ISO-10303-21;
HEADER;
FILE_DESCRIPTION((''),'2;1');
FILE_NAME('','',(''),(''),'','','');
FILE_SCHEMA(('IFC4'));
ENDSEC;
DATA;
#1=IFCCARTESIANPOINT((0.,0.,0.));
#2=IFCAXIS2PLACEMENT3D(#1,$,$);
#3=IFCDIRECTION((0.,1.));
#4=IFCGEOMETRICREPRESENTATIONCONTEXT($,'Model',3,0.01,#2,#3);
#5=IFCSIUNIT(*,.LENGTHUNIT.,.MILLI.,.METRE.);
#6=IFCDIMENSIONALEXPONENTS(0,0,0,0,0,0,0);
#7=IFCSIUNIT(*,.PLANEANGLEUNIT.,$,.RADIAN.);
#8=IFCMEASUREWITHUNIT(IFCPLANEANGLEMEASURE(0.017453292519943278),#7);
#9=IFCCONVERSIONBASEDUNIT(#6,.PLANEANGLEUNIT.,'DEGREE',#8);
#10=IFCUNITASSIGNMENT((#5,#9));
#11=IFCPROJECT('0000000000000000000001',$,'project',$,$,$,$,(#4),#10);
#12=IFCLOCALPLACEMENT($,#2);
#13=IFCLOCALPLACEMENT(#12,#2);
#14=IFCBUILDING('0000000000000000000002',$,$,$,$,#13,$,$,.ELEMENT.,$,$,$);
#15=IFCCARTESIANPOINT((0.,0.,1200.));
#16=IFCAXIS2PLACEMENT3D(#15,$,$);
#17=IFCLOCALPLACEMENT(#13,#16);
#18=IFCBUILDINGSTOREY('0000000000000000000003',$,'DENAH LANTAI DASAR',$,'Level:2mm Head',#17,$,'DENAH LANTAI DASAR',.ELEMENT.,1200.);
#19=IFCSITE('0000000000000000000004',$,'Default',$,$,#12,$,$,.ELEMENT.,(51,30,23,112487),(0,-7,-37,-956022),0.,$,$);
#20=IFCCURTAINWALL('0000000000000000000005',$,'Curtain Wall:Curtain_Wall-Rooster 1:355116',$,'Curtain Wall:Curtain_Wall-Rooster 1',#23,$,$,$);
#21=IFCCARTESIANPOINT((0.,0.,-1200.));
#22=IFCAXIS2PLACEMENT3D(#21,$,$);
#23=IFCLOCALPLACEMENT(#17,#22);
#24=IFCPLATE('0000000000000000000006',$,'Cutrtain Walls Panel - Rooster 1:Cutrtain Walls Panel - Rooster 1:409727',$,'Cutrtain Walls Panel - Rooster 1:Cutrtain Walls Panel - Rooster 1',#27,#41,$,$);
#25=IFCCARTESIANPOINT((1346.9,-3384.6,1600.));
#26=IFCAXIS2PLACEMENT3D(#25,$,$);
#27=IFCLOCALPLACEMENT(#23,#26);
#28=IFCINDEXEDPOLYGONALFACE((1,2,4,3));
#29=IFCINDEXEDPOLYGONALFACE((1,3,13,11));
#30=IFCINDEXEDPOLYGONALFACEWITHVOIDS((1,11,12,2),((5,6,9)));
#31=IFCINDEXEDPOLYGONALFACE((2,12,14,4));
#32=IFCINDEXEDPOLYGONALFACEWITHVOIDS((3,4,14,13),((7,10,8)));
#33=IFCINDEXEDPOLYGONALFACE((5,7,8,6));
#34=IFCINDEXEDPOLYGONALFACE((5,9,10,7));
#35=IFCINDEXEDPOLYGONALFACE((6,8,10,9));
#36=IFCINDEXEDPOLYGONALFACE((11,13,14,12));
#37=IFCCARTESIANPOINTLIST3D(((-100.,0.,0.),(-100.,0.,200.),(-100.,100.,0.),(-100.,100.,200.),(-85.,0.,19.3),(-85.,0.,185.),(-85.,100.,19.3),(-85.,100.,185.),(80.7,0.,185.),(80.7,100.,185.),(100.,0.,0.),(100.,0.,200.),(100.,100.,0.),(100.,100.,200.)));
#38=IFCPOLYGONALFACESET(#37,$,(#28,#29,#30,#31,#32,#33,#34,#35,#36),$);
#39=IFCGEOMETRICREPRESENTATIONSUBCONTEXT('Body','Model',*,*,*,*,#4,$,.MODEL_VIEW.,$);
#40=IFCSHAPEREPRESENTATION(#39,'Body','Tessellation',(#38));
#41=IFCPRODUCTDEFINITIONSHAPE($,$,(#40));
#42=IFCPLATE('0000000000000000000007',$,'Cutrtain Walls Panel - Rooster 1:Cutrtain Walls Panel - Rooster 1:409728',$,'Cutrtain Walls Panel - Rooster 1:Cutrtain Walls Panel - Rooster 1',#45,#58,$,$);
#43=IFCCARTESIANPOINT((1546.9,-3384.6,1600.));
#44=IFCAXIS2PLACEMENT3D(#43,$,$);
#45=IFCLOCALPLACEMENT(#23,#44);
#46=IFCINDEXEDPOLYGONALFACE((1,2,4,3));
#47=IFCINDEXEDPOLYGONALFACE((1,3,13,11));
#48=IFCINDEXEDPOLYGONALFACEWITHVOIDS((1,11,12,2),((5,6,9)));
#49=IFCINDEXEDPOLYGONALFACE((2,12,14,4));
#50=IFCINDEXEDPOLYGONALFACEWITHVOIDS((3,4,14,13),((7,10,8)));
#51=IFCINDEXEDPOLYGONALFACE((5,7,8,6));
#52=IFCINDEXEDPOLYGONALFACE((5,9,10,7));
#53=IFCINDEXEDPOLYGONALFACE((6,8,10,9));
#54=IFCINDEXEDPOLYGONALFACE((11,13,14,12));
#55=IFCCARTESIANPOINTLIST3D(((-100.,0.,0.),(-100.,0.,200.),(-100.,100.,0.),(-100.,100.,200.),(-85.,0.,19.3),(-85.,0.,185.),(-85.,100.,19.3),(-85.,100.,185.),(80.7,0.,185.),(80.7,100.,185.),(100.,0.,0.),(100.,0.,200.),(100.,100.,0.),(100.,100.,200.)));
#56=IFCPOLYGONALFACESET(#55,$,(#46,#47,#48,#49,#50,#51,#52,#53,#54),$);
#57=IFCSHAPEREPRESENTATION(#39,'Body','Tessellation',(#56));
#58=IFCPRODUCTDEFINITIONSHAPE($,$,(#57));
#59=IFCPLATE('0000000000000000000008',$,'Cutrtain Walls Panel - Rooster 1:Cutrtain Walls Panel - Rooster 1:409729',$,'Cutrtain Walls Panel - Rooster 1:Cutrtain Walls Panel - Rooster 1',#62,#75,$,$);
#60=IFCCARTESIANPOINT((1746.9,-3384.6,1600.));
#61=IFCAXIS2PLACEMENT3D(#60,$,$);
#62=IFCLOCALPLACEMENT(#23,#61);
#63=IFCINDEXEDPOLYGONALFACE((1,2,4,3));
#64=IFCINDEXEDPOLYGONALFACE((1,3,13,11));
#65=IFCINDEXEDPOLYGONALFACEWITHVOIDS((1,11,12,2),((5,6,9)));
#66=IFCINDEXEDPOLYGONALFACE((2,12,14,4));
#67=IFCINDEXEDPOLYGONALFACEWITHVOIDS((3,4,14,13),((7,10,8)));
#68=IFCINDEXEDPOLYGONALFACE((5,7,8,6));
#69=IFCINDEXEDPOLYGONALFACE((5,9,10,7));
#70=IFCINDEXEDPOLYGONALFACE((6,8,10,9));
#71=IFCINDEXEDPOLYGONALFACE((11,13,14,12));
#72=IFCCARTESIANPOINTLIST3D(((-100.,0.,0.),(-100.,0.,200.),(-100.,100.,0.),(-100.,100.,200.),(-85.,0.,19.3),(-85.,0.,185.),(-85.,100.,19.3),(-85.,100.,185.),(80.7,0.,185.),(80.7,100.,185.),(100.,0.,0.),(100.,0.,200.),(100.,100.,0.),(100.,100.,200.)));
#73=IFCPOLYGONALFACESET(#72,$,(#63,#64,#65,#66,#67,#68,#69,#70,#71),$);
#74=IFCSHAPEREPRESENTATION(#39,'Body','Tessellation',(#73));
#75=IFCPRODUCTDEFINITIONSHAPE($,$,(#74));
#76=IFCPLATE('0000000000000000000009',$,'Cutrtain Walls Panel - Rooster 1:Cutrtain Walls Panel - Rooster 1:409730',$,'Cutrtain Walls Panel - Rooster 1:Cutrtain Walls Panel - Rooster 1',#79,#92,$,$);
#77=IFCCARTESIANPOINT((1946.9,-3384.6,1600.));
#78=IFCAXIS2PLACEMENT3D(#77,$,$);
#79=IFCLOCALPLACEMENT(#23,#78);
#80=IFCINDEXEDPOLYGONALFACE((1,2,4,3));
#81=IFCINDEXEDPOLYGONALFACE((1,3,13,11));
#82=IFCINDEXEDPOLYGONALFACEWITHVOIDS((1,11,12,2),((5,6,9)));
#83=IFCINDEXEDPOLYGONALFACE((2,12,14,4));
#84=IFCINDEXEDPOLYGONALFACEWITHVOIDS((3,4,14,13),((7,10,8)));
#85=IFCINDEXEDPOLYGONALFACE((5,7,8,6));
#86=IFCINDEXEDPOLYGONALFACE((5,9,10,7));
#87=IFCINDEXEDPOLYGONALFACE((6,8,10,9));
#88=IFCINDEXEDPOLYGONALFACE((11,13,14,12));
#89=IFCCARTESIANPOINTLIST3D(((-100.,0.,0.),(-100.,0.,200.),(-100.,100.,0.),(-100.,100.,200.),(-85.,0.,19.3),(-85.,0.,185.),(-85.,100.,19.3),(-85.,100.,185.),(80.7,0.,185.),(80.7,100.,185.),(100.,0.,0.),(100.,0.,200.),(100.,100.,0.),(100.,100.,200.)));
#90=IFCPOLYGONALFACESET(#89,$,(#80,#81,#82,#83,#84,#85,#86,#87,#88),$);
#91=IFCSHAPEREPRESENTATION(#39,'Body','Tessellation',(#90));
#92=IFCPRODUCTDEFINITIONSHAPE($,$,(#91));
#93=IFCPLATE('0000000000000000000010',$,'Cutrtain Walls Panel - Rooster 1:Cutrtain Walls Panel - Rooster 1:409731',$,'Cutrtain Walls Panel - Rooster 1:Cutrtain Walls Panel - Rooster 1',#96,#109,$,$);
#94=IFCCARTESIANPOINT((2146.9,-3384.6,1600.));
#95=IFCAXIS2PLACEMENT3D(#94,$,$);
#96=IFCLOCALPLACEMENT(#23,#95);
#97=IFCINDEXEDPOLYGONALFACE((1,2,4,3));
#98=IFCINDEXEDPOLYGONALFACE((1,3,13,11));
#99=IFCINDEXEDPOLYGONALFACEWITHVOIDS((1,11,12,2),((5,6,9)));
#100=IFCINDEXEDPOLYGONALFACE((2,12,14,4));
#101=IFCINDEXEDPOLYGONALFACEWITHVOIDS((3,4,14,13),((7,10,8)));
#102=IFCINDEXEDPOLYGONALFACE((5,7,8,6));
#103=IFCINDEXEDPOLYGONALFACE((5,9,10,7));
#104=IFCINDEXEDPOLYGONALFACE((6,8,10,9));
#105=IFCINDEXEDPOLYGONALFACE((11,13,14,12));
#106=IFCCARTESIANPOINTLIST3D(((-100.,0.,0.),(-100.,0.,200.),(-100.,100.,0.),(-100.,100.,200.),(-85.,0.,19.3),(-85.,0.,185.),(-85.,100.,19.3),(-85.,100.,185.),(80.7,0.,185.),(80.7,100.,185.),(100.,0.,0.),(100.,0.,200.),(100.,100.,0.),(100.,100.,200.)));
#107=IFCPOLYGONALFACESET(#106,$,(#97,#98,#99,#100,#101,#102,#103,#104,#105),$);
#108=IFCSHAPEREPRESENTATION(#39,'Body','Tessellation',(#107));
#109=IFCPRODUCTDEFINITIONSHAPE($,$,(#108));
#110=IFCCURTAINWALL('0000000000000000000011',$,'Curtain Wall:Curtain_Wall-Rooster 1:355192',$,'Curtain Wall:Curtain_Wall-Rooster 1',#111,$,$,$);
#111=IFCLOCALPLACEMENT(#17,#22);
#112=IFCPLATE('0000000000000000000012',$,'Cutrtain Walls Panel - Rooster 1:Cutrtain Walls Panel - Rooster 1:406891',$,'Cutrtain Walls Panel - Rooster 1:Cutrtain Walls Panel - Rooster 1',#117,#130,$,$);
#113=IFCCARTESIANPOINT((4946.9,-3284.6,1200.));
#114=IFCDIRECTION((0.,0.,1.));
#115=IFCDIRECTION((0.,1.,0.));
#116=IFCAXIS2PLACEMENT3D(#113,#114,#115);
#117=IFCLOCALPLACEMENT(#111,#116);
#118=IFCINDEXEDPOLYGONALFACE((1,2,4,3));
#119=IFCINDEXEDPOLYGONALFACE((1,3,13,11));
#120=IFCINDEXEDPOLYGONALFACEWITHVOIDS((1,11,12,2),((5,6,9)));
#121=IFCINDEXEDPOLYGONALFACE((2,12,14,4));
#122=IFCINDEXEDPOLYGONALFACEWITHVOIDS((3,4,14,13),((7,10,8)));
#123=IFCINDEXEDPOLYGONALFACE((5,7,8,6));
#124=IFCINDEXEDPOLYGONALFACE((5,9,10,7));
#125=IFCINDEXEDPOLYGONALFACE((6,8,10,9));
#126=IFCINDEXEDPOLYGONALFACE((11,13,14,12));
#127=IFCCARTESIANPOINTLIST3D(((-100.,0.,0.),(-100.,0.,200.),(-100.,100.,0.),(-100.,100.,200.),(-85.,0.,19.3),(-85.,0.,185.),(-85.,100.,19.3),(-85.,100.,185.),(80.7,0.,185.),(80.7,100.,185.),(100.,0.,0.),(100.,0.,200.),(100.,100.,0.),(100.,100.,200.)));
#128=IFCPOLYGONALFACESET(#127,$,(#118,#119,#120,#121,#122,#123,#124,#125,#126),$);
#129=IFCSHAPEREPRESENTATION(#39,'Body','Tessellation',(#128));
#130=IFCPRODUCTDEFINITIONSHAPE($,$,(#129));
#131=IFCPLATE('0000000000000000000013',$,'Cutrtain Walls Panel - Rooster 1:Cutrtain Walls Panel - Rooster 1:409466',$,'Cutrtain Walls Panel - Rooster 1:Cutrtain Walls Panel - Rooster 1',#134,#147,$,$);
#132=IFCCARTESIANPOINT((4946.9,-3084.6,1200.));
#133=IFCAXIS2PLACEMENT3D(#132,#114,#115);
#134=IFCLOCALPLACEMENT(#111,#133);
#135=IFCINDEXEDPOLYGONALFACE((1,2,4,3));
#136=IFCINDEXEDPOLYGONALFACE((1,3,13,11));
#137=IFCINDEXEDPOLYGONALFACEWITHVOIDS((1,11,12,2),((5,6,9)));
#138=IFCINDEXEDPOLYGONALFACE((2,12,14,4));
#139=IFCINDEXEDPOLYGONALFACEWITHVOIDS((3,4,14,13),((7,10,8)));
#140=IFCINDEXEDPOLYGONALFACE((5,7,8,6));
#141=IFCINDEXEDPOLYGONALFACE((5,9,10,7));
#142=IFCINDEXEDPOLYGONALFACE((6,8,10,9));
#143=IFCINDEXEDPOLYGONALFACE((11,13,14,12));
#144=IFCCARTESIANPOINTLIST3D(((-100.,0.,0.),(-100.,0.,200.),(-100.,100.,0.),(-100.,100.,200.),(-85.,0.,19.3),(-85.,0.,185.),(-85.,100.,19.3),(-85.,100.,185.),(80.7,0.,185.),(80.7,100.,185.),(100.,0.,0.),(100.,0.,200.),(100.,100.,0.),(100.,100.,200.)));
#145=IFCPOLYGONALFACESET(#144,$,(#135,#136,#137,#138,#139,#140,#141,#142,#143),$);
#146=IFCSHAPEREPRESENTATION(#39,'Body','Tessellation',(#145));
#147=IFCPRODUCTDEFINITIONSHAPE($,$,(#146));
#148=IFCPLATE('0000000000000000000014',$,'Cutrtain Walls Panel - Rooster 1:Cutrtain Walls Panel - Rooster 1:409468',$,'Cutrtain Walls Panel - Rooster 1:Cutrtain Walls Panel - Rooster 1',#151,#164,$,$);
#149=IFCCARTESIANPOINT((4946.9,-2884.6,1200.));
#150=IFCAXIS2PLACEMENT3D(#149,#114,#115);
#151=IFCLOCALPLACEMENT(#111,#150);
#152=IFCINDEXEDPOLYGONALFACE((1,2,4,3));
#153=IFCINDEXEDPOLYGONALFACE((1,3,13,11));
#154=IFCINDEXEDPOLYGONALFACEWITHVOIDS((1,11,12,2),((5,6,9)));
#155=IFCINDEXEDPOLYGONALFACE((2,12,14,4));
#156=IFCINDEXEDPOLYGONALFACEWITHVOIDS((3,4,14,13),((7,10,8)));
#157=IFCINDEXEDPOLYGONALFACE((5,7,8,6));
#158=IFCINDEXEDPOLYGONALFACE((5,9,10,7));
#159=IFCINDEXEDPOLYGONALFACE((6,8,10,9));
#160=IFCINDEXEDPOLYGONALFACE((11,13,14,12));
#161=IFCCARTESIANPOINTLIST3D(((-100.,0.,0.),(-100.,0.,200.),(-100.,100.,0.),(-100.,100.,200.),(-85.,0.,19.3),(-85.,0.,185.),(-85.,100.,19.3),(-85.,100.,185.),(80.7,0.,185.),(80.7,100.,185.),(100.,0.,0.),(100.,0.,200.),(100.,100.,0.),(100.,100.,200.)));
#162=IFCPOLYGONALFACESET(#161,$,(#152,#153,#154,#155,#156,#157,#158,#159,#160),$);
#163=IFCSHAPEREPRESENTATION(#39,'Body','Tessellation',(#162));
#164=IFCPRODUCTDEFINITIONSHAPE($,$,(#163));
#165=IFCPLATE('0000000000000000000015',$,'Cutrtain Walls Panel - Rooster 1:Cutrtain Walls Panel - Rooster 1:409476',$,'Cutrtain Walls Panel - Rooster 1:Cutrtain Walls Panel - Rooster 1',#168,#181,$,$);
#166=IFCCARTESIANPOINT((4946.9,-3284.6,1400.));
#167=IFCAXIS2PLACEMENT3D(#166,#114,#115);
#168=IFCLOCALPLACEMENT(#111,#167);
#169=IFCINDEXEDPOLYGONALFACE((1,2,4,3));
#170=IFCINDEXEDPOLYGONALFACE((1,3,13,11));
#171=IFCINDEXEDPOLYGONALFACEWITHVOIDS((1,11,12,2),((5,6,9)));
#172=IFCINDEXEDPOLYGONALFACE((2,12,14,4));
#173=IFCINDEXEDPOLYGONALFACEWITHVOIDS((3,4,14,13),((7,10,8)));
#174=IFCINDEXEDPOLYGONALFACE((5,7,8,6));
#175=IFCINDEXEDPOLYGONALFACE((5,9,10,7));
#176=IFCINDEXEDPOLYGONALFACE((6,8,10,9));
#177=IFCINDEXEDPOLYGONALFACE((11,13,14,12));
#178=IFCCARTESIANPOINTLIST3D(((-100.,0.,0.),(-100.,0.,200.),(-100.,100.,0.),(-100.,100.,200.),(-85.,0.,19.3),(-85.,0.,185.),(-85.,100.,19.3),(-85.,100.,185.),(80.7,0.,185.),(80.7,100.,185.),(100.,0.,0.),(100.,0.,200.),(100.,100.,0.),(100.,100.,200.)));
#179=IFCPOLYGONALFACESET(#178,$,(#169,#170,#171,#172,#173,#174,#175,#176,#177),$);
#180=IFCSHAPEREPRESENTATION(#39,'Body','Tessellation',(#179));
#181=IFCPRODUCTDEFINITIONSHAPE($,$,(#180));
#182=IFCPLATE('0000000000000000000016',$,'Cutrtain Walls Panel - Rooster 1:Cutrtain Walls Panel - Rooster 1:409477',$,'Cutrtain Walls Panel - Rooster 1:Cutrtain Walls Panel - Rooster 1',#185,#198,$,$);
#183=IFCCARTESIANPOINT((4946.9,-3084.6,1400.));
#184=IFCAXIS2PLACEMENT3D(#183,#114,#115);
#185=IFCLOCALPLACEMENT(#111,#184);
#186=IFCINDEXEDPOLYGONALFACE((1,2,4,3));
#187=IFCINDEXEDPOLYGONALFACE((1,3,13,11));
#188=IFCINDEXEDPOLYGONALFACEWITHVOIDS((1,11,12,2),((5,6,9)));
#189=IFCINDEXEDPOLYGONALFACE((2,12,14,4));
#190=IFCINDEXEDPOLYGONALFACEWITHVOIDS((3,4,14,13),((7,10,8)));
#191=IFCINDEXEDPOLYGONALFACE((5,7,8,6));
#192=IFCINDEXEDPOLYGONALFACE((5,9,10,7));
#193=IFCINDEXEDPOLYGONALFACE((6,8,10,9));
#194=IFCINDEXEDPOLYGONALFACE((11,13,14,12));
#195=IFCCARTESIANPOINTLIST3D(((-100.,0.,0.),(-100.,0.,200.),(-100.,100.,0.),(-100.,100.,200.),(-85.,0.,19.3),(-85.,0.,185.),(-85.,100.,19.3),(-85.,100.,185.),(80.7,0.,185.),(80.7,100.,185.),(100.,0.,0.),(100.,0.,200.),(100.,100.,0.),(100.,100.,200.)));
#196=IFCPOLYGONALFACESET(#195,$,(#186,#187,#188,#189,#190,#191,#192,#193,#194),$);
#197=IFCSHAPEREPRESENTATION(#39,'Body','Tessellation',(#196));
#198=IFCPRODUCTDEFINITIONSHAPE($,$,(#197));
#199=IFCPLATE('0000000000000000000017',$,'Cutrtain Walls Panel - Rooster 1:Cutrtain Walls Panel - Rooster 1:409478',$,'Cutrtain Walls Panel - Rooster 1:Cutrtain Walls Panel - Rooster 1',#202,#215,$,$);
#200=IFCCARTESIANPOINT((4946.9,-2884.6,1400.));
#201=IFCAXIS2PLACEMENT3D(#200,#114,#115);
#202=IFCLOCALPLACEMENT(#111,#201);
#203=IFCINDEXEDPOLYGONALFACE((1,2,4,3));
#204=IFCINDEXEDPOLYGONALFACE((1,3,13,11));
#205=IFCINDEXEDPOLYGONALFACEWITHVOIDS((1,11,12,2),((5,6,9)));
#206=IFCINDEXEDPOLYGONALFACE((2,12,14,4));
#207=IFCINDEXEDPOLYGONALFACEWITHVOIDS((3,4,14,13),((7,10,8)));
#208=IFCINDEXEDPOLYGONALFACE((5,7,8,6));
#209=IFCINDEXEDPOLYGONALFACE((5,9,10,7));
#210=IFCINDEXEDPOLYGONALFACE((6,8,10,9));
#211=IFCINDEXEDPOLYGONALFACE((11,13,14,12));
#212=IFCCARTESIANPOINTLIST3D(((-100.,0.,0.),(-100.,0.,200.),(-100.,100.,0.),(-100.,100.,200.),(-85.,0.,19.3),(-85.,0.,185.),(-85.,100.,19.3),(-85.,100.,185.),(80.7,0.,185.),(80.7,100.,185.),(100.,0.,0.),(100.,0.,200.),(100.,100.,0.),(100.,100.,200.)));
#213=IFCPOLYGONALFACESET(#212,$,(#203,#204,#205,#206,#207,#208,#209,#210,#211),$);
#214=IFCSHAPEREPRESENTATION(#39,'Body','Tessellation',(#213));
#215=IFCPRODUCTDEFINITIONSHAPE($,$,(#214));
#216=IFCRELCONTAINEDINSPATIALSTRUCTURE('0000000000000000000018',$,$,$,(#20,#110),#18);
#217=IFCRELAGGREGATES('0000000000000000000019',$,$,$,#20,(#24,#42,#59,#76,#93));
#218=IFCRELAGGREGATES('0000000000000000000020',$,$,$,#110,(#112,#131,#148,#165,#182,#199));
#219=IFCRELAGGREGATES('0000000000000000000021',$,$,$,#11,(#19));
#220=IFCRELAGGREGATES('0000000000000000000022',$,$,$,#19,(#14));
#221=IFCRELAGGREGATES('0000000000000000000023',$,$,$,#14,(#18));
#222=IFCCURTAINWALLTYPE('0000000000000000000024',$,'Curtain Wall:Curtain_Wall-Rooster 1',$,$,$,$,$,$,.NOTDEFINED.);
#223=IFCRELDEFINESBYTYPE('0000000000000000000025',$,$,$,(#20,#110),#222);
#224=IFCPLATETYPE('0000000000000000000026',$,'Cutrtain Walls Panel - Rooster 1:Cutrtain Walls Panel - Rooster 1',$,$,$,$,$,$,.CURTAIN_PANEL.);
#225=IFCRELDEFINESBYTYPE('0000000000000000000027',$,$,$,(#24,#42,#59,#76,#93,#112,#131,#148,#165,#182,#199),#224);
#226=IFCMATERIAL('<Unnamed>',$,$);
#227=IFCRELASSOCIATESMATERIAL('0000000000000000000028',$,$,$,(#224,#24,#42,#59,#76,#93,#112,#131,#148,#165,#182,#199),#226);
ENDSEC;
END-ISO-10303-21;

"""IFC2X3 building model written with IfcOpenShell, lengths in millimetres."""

from ifc_helpers import new_model, entity, si_unit, converted_unit, direction, frame, origin, place, context, subcontext, project, spatial, polyline, outline, extrude, source, transform, mapped, material, type_object, type_shapes, element, aggregate, save


model = new_model("IFC2X3")

# Units and contexts
model_context = context("Model", 3, precision=0.01, world=origin(), true_north=direction((0.0, 1.0)))
body_context = subcontext(model_context, "Body", "Model", "MODEL_VIEW")
ifc_project = project(units=[si_unit("LENGTHUNIT", "METRE", prefix="MILLI"), converted_unit("PLANEANGLEUNIT", "DEGREE", entity("IfcPlaneAngleMeasure", 0.017453292519943278), si_unit("PLANEANGLEUNIT", "RADIAN"), dimensions=[0, 0, 0, 0, 0, 0, 0])], contexts=[model_context])

# Site, building, storey
site_placement = place(None, origin())
site = spatial("IfcSite", under=ifc_project, at=site_placement, Name="Default", CompositionType="ELEMENT", RefLatitude=(51, 30, 23, 112487), RefLongitude=(0, -7, -37, -956022), RefElevation=0.0)
building_placement = place(site_placement, origin())
building = spatial("IfcBuilding", under=site, at=building_placement, CompositionType="ELEMENT")
storey_placement = place(building_placement, frame((0.0, 0.0, 1200.0)))
storey = spatial("IfcBuildingStorey", under=building, at=storey_placement, Name="DENAH LANTAI DASAR", ObjectType="Level:2mm Head", LongName="DENAH LANTAI DASAR", CompositionType="ELEMENT", Elevation=1200.0)

# Curtain walls, plates
curtain_wall_type = type_object("IfcCurtainWallType", Name="Curtain Wall:Curtain_Wall-Rooster 1", PredefinedType="NOTDEFINED")
curtain_wall_1_placement = place(storey_placement, frame((0.0, 0.0, -1200.0)))
curtain_wall_1 = element("IfcCurtainWall", 1, at=curtain_wall_1_placement, inside=storey, type_object=curtain_wall_type, Name="Curtain Wall:Curtain_Wall-Rooster 1:355116", ObjectType="Curtain Wall:Curtain_Wall-Rooster 1")
ifc_material_1 = material(Name="<Unnamed>")
plate_type = type_object("IfcPlateType", Name="Cutrtain Walls Panel - Rooster 1:Cutrtain Walls Panel - Rooster 1", PredefinedType="CURTAIN_PANEL", material=ifc_material_1)
shared_shape = source(origin(), body_context, "Body", "SweptSolid", [
    extrude(outline(polyline([(-100.0, -100.0), (100.0, -100.0), (100.0, 100.0), (-100.0, 100.0), (-100.0, -100.0)]), holes=[polyline([(80.7, 85.0), (-85.0, -80.7), (-85.0, 85.0), (80.7, 85.0)])]), frame((0.0, 0.0, 100.0), z_axis=(0.0, 1.0, 0.0), x_axis=(0.0, 0.0, -1.0)), (0.0, 0.0, 1.0), 100.0),
])
type_shapes(plate_type, [shared_shape])
plate_1_placement = place(curtain_wall_1_placement, frame((1346.9, -3384.6, 1600.0)))
plate_1 = element("IfcPlate", 2, at=plate_1_placement, type_object=plate_type, material=ifc_material_1, Name="Cutrtain Walls Panel - Rooster 1:Cutrtain Walls Panel - Rooster 1:409727", ObjectType="Cutrtain Walls Panel - Rooster 1:Cutrtain Walls Panel - Rooster 1", context=body_context, shape_type="MappedRepresentation", body=[
    mapped(shared_shape, transform((0.0, 0.0, 0.0), scale=1.0)),
])
plate_2_placement = place(curtain_wall_1_placement, frame((1546.9, -3384.6, 1600.0)))
plate_2 = element("IfcPlate", 3, at=plate_2_placement, type_object=plate_type, material=ifc_material_1, Name="Cutrtain Walls Panel - Rooster 1:Cutrtain Walls Panel - Rooster 1:409728", ObjectType="Cutrtain Walls Panel - Rooster 1:Cutrtain Walls Panel - Rooster 1", context=body_context, shape_type="MappedRepresentation", body=[
    mapped(shared_shape, transform((0.0, 0.0, 0.0), scale=1.0)),
])
plate_3_placement = place(curtain_wall_1_placement, frame((1746.9, -3384.6, 1600.0)))
plate_3 = element("IfcPlate", 4, at=plate_3_placement, type_object=plate_type, material=ifc_material_1, Name="Cutrtain Walls Panel - Rooster 1:Cutrtain Walls Panel - Rooster 1:409729", ObjectType="Cutrtain Walls Panel - Rooster 1:Cutrtain Walls Panel - Rooster 1", context=body_context, shape_type="MappedRepresentation", body=[
    mapped(shared_shape, transform((0.0, 0.0, 0.0), scale=1.0)),
])
plate_4_placement = place(curtain_wall_1_placement, frame((1946.9, -3384.6, 1600.0)))
plate_4 = element("IfcPlate", 5, at=plate_4_placement, type_object=plate_type, material=ifc_material_1, Name="Cutrtain Walls Panel - Rooster 1:Cutrtain Walls Panel - Rooster 1:409730", ObjectType="Cutrtain Walls Panel - Rooster 1:Cutrtain Walls Panel - Rooster 1", context=body_context, shape_type="MappedRepresentation", body=[
    mapped(shared_shape, transform((0.0, 0.0, 0.0), scale=1.0)),
])
plate_5_placement = place(curtain_wall_1_placement, frame((2146.9, -3384.6, 1600.0)))
plate_5 = element("IfcPlate", 6, at=plate_5_placement, type_object=plate_type, material=ifc_material_1, Name="Cutrtain Walls Panel - Rooster 1:Cutrtain Walls Panel - Rooster 1:409731", ObjectType="Cutrtain Walls Panel - Rooster 1:Cutrtain Walls Panel - Rooster 1", context=body_context, shape_type="MappedRepresentation", body=[
    mapped(shared_shape, transform((0.0, 0.0, 0.0), scale=1.0)),
])
aggregate(curtain_wall_1, [plate_1, plate_2, plate_3, plate_4, plate_5])
curtain_wall_2_placement = place(storey_placement, frame((0.0, 0.0, -1200.0)))
curtain_wall_2 = element("IfcCurtainWall", 7, at=curtain_wall_2_placement, inside=storey, type_object=curtain_wall_type, Name="Curtain Wall:Curtain_Wall-Rooster 1:355192", ObjectType="Curtain Wall:Curtain_Wall-Rooster 1")
plate_6_placement = place(curtain_wall_2_placement, frame((4946.9, -3284.6, 1200.0), z_axis=(0.0, 0.0, 1.0), x_axis=(0.0, 1.0, 0.0)))
plate_6 = element("IfcPlate", 8, at=plate_6_placement, type_object=plate_type, material=ifc_material_1, Name="Cutrtain Walls Panel - Rooster 1:Cutrtain Walls Panel - Rooster 1:406891", ObjectType="Cutrtain Walls Panel - Rooster 1:Cutrtain Walls Panel - Rooster 1", context=body_context, shape_type="MappedRepresentation", body=[
    mapped(shared_shape, transform((0.0, 0.0, 0.0), scale=1.0)),
])
plate_7_placement = place(curtain_wall_2_placement, frame((4946.9, -3084.6, 1200.0), z_axis=(0.0, 0.0, 1.0), x_axis=(0.0, 1.0, 0.0)))
plate_7 = element("IfcPlate", 9, at=plate_7_placement, type_object=plate_type, material=ifc_material_1, Name="Cutrtain Walls Panel - Rooster 1:Cutrtain Walls Panel - Rooster 1:409466", ObjectType="Cutrtain Walls Panel - Rooster 1:Cutrtain Walls Panel - Rooster 1", context=body_context, shape_type="MappedRepresentation", body=[
    mapped(shared_shape, transform((0.0, 0.0, 0.0), scale=1.0)),
])
plate_8_placement = place(curtain_wall_2_placement, frame((4946.9, -2884.6, 1200.0), z_axis=(0.0, 0.0, 1.0), x_axis=(0.0, 1.0, 0.0)))
plate_8 = element("IfcPlate", 10, at=plate_8_placement, type_object=plate_type, material=ifc_material_1, Name="Cutrtain Walls Panel - Rooster 1:Cutrtain Walls Panel - Rooster 1:409468", ObjectType="Cutrtain Walls Panel - Rooster 1:Cutrtain Walls Panel - Rooster 1", context=body_context, shape_type="MappedRepresentation", body=[
    mapped(shared_shape, transform((0.0, 0.0, 0.0), scale=1.0)),
])
plate_9_placement = place(curtain_wall_2_placement, frame((4946.9, -3284.6, 1400.0), z_axis=(0.0, 0.0, 1.0), x_axis=(0.0, 1.0, 0.0)))
plate_9 = element("IfcPlate", 11, at=plate_9_placement, type_object=plate_type, material=ifc_material_1, Name="Cutrtain Walls Panel - Rooster 1:Cutrtain Walls Panel - Rooster 1:409476", ObjectType="Cutrtain Walls Panel - Rooster 1:Cutrtain Walls Panel - Rooster 1", context=body_context, shape_type="MappedRepresentation", body=[
    mapped(shared_shape, transform((0.0, 0.0, 0.0), scale=1.0)),
])
plate_10_placement = place(curtain_wall_2_placement, frame((4946.9, -3084.6, 1400.0), z_axis=(0.0, 0.0, 1.0), x_axis=(0.0, 1.0, 0.0)))
plate_10 = element("IfcPlate", 12, at=plate_10_placement, type_object=plate_type, material=ifc_material_1, Name="Cutrtain Walls Panel - Rooster 1:Cutrtain Walls Panel - Rooster 1:409477", ObjectType="Cutrtain Walls Panel - Rooster 1:Cutrtain Walls Panel - Rooster 1", context=body_context, shape_type="MappedRepresentation", body=[
    mapped(shared_shape, transform((0.0, 0.0, 0.0), scale=1.0)),
])
plate_11_placement = place(curtain_wall_2_placement, frame((4946.9, -2884.6, 1400.0), z_axis=(0.0, 0.0, 1.0), x_axis=(0.0, 1.0, 0.0)))
plate_11 = element("IfcPlate", 13, at=plate_11_placement, type_object=plate_type, material=ifc_material_1, Name="Cutrtain Walls Panel - Rooster 1:Cutrtain Walls Panel - Rooster 1:409478", ObjectType="Cutrtain Walls Panel - Rooster 1:Cutrtain Walls Panel - Rooster 1", context=body_context, shape_type="MappedRepresentation", body=[
    mapped(shared_shape, transform((0.0, 0.0, 0.0), scale=1.0)),
])
aggregate(curtain_wall_2, [plate_6, plate_7, plate_8, plate_9, plate_10, plate_11])

save(model, "model.ifc")
